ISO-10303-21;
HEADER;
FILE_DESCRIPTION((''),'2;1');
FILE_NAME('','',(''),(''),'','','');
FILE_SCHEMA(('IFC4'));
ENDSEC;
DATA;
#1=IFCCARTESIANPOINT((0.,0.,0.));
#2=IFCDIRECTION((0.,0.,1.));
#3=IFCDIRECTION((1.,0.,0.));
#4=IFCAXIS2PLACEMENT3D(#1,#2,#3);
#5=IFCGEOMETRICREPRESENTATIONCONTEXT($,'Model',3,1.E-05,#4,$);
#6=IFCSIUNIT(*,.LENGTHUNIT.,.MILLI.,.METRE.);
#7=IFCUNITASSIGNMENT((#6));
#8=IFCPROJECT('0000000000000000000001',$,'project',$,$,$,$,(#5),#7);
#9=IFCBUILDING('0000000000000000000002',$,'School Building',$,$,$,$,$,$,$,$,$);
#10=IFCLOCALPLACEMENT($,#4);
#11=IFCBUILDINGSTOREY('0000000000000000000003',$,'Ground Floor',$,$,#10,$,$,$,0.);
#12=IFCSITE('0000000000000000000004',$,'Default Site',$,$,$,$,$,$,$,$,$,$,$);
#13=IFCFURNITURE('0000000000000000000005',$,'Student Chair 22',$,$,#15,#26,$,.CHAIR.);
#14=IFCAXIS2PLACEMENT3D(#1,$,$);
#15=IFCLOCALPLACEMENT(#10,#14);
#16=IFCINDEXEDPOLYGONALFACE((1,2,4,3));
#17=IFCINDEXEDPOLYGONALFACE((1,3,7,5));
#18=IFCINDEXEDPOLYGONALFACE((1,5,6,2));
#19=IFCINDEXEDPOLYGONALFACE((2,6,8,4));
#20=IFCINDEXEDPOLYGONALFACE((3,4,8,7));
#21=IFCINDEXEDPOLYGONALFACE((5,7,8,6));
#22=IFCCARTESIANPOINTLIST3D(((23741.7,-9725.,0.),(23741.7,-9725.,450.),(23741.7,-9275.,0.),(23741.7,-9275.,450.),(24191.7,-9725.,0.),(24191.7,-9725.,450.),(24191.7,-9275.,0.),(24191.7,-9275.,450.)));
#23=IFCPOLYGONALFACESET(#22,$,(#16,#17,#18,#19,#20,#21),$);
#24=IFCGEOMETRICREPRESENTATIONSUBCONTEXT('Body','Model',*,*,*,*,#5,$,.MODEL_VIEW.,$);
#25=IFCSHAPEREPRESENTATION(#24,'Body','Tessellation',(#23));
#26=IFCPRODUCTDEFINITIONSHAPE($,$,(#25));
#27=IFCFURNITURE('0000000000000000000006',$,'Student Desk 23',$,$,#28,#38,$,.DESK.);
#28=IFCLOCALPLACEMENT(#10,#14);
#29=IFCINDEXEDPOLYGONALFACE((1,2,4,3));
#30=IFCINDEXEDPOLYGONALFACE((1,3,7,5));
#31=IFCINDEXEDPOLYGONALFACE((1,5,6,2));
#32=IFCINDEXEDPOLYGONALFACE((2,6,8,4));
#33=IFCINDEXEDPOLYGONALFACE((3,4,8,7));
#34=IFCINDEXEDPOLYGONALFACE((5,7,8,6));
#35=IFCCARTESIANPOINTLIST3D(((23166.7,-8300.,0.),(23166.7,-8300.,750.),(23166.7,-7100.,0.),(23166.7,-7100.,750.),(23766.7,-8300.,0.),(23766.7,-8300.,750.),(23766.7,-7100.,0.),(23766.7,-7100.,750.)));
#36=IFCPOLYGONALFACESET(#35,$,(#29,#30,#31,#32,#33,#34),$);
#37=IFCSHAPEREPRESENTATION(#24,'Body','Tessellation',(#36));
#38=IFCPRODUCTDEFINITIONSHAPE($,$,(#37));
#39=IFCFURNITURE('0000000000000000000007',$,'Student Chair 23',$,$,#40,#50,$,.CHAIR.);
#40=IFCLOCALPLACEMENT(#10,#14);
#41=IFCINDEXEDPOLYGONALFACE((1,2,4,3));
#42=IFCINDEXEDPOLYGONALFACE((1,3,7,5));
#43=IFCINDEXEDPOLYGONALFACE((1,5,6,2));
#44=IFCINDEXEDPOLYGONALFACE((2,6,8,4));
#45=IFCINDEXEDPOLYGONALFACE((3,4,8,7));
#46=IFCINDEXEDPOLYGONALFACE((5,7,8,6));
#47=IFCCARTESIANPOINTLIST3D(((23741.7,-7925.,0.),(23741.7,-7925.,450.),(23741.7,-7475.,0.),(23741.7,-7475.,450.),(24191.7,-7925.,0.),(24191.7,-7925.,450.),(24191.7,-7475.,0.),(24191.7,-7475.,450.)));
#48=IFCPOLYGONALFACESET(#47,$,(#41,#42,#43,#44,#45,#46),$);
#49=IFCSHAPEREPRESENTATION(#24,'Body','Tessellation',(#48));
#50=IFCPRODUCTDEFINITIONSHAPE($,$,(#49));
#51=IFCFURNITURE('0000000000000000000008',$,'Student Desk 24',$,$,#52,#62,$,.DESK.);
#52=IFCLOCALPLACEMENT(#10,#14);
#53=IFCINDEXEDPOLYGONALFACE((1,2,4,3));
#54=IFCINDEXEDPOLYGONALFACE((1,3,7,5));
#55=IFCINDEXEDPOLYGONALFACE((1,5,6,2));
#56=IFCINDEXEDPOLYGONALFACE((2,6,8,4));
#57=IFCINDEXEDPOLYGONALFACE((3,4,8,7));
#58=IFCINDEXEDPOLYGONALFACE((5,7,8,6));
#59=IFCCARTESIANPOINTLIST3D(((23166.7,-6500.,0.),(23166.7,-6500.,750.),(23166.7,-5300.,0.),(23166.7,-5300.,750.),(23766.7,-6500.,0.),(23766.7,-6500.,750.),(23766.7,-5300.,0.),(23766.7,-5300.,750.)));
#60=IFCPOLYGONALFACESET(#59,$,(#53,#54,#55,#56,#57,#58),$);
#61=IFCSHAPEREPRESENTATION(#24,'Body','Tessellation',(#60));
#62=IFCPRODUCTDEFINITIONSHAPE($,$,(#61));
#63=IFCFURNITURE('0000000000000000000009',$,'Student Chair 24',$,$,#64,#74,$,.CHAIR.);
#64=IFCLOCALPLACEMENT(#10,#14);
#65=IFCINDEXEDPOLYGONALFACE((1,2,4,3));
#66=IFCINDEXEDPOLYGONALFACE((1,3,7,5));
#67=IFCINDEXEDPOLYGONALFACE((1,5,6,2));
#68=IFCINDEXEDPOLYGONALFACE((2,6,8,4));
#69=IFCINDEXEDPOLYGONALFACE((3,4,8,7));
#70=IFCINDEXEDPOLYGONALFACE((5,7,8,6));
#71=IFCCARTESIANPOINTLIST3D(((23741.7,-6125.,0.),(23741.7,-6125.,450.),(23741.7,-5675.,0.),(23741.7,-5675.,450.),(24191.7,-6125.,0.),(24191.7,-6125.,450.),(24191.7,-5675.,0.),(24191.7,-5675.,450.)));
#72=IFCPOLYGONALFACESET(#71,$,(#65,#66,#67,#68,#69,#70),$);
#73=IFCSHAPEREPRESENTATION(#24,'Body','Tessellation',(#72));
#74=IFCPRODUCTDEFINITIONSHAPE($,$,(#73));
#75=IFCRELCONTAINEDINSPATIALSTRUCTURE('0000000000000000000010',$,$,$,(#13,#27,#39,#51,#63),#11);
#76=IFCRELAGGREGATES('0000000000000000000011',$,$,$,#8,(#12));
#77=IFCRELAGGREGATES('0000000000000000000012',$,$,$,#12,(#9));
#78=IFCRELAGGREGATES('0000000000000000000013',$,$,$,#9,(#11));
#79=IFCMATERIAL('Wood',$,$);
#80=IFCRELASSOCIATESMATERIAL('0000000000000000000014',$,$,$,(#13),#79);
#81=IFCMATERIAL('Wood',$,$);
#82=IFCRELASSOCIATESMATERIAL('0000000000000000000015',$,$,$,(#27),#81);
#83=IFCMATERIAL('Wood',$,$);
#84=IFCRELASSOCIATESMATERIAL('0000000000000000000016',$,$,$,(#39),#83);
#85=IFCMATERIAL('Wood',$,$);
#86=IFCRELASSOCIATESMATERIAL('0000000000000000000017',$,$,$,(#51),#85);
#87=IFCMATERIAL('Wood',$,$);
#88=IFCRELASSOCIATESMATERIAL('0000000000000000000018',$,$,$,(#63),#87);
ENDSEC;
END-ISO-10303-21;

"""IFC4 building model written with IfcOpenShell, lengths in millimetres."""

from ifc_helpers import new_model, si_unit, frame, origin_with_axes, origin_2d, place, context, subcontext, project, spatial, rectangle, extrude, material, element, save


model = new_model("IFC4")

# Units and contexts
model_context = context("Model", 3, precision=1e-05, world=origin_with_axes())
body_context = subcontext(model_context, "Body", "Model", "MODEL_VIEW")
ifc_project = project(units=[si_unit("LENGTHUNIT", "METRE", prefix="MILLI")], contexts=[model_context])

# Site, building, storey
site = spatial("IfcSite", under=ifc_project, Name="Default Site")
building = spatial("IfcBuilding", under=site, Name="School Building")
storey_placement = place(None, origin_with_axes())
storey = spatial("IfcBuildingStorey", under=building, at=storey_placement, Name="Ground Floor", Elevation=0.0)

# Furniture
ifc_material_1 = material(Name="Wood")
furniture_1_placement = place(storey_placement, frame((23966.7, -9500.0, 0.0), z_axis=(0.0, 0.0, 1.0), x_axis=(1.0, 0.0, 0.0)))
element("IfcFurniture", 1, at=furniture_1_placement, inside=storey, material=ifc_material_1, Name="Student Chair 22", PredefinedType="CHAIR", context=body_context, shape_type="SweptSolid", body=[
    extrude(rectangle(XDim=450.0, YDim=450.0, at=origin_2d()), origin_with_axes(), (0.0, 0.0, 1.0), 450.0),
])
ifc_material_2 = material(Name="Wood")
furniture_2_placement = place(storey_placement, frame((23466.7, -7700.0, 0.0), z_axis=(0.0, 0.0, 1.0), x_axis=(0.0, 1.0, 0.0)))
element("IfcFurniture", 2, at=furniture_2_placement, inside=storey, material=ifc_material_2, Name="Student Desk 23", PredefinedType="DESK", context=body_context, shape_type="SweptSolid", body=[
    extrude(rectangle(XDim=1200.0, YDim=600.0, at=origin_2d()), origin_with_axes(), (0.0, 0.0, 1.0), 750.0),
])
ifc_material_3 = material(Name="Wood")
furniture_3_placement = place(storey_placement, frame((23966.7, -7700.0, 0.0), z_axis=(0.0, 0.0, 1.0), x_axis=(1.0, 0.0, 0.0)))
element("IfcFurniture", 3, at=furniture_3_placement, inside=storey, material=ifc_material_3, Name="Student Chair 23", PredefinedType="CHAIR", context=body_context, shape_type="SweptSolid", body=[
    extrude(rectangle(XDim=450.0, YDim=450.0, at=origin_2d()), origin_with_axes(), (0.0, 0.0, 1.0), 450.0),
])
ifc_material_4 = material(Name="Wood")
furniture_4_placement = place(storey_placement, frame((23466.7, -5900.0, 0.0), z_axis=(0.0, 0.0, 1.0), x_axis=(0.0, 1.0, 0.0)))
element("IfcFurniture", 4, at=furniture_4_placement, inside=storey, material=ifc_material_4, Name="Student Desk 24", PredefinedType="DESK", context=body_context, shape_type="SweptSolid", body=[
    extrude(rectangle(XDim=1200.0, YDim=600.0, at=origin_2d()), origin_with_axes(), (0.0, 0.0, 1.0), 750.0),
])
ifc_material_5 = material(Name="Wood")
furniture_5_placement = place(storey_placement, frame((23966.7, -5900.0, 0.0), z_axis=(0.0, 0.0, 1.0), x_axis=(1.0, 0.0, 0.0)))
element("IfcFurniture", 5, at=furniture_5_placement, inside=storey, material=ifc_material_5, Name="Student Chair 24", PredefinedType="CHAIR", context=body_context, shape_type="SweptSolid", body=[
    extrude(rectangle(XDim=450.0, YDim=450.0, at=origin_2d()), origin_with_axes(), (0.0, 0.0, 1.0), 450.0),
])

save(model, "model.ifc")
